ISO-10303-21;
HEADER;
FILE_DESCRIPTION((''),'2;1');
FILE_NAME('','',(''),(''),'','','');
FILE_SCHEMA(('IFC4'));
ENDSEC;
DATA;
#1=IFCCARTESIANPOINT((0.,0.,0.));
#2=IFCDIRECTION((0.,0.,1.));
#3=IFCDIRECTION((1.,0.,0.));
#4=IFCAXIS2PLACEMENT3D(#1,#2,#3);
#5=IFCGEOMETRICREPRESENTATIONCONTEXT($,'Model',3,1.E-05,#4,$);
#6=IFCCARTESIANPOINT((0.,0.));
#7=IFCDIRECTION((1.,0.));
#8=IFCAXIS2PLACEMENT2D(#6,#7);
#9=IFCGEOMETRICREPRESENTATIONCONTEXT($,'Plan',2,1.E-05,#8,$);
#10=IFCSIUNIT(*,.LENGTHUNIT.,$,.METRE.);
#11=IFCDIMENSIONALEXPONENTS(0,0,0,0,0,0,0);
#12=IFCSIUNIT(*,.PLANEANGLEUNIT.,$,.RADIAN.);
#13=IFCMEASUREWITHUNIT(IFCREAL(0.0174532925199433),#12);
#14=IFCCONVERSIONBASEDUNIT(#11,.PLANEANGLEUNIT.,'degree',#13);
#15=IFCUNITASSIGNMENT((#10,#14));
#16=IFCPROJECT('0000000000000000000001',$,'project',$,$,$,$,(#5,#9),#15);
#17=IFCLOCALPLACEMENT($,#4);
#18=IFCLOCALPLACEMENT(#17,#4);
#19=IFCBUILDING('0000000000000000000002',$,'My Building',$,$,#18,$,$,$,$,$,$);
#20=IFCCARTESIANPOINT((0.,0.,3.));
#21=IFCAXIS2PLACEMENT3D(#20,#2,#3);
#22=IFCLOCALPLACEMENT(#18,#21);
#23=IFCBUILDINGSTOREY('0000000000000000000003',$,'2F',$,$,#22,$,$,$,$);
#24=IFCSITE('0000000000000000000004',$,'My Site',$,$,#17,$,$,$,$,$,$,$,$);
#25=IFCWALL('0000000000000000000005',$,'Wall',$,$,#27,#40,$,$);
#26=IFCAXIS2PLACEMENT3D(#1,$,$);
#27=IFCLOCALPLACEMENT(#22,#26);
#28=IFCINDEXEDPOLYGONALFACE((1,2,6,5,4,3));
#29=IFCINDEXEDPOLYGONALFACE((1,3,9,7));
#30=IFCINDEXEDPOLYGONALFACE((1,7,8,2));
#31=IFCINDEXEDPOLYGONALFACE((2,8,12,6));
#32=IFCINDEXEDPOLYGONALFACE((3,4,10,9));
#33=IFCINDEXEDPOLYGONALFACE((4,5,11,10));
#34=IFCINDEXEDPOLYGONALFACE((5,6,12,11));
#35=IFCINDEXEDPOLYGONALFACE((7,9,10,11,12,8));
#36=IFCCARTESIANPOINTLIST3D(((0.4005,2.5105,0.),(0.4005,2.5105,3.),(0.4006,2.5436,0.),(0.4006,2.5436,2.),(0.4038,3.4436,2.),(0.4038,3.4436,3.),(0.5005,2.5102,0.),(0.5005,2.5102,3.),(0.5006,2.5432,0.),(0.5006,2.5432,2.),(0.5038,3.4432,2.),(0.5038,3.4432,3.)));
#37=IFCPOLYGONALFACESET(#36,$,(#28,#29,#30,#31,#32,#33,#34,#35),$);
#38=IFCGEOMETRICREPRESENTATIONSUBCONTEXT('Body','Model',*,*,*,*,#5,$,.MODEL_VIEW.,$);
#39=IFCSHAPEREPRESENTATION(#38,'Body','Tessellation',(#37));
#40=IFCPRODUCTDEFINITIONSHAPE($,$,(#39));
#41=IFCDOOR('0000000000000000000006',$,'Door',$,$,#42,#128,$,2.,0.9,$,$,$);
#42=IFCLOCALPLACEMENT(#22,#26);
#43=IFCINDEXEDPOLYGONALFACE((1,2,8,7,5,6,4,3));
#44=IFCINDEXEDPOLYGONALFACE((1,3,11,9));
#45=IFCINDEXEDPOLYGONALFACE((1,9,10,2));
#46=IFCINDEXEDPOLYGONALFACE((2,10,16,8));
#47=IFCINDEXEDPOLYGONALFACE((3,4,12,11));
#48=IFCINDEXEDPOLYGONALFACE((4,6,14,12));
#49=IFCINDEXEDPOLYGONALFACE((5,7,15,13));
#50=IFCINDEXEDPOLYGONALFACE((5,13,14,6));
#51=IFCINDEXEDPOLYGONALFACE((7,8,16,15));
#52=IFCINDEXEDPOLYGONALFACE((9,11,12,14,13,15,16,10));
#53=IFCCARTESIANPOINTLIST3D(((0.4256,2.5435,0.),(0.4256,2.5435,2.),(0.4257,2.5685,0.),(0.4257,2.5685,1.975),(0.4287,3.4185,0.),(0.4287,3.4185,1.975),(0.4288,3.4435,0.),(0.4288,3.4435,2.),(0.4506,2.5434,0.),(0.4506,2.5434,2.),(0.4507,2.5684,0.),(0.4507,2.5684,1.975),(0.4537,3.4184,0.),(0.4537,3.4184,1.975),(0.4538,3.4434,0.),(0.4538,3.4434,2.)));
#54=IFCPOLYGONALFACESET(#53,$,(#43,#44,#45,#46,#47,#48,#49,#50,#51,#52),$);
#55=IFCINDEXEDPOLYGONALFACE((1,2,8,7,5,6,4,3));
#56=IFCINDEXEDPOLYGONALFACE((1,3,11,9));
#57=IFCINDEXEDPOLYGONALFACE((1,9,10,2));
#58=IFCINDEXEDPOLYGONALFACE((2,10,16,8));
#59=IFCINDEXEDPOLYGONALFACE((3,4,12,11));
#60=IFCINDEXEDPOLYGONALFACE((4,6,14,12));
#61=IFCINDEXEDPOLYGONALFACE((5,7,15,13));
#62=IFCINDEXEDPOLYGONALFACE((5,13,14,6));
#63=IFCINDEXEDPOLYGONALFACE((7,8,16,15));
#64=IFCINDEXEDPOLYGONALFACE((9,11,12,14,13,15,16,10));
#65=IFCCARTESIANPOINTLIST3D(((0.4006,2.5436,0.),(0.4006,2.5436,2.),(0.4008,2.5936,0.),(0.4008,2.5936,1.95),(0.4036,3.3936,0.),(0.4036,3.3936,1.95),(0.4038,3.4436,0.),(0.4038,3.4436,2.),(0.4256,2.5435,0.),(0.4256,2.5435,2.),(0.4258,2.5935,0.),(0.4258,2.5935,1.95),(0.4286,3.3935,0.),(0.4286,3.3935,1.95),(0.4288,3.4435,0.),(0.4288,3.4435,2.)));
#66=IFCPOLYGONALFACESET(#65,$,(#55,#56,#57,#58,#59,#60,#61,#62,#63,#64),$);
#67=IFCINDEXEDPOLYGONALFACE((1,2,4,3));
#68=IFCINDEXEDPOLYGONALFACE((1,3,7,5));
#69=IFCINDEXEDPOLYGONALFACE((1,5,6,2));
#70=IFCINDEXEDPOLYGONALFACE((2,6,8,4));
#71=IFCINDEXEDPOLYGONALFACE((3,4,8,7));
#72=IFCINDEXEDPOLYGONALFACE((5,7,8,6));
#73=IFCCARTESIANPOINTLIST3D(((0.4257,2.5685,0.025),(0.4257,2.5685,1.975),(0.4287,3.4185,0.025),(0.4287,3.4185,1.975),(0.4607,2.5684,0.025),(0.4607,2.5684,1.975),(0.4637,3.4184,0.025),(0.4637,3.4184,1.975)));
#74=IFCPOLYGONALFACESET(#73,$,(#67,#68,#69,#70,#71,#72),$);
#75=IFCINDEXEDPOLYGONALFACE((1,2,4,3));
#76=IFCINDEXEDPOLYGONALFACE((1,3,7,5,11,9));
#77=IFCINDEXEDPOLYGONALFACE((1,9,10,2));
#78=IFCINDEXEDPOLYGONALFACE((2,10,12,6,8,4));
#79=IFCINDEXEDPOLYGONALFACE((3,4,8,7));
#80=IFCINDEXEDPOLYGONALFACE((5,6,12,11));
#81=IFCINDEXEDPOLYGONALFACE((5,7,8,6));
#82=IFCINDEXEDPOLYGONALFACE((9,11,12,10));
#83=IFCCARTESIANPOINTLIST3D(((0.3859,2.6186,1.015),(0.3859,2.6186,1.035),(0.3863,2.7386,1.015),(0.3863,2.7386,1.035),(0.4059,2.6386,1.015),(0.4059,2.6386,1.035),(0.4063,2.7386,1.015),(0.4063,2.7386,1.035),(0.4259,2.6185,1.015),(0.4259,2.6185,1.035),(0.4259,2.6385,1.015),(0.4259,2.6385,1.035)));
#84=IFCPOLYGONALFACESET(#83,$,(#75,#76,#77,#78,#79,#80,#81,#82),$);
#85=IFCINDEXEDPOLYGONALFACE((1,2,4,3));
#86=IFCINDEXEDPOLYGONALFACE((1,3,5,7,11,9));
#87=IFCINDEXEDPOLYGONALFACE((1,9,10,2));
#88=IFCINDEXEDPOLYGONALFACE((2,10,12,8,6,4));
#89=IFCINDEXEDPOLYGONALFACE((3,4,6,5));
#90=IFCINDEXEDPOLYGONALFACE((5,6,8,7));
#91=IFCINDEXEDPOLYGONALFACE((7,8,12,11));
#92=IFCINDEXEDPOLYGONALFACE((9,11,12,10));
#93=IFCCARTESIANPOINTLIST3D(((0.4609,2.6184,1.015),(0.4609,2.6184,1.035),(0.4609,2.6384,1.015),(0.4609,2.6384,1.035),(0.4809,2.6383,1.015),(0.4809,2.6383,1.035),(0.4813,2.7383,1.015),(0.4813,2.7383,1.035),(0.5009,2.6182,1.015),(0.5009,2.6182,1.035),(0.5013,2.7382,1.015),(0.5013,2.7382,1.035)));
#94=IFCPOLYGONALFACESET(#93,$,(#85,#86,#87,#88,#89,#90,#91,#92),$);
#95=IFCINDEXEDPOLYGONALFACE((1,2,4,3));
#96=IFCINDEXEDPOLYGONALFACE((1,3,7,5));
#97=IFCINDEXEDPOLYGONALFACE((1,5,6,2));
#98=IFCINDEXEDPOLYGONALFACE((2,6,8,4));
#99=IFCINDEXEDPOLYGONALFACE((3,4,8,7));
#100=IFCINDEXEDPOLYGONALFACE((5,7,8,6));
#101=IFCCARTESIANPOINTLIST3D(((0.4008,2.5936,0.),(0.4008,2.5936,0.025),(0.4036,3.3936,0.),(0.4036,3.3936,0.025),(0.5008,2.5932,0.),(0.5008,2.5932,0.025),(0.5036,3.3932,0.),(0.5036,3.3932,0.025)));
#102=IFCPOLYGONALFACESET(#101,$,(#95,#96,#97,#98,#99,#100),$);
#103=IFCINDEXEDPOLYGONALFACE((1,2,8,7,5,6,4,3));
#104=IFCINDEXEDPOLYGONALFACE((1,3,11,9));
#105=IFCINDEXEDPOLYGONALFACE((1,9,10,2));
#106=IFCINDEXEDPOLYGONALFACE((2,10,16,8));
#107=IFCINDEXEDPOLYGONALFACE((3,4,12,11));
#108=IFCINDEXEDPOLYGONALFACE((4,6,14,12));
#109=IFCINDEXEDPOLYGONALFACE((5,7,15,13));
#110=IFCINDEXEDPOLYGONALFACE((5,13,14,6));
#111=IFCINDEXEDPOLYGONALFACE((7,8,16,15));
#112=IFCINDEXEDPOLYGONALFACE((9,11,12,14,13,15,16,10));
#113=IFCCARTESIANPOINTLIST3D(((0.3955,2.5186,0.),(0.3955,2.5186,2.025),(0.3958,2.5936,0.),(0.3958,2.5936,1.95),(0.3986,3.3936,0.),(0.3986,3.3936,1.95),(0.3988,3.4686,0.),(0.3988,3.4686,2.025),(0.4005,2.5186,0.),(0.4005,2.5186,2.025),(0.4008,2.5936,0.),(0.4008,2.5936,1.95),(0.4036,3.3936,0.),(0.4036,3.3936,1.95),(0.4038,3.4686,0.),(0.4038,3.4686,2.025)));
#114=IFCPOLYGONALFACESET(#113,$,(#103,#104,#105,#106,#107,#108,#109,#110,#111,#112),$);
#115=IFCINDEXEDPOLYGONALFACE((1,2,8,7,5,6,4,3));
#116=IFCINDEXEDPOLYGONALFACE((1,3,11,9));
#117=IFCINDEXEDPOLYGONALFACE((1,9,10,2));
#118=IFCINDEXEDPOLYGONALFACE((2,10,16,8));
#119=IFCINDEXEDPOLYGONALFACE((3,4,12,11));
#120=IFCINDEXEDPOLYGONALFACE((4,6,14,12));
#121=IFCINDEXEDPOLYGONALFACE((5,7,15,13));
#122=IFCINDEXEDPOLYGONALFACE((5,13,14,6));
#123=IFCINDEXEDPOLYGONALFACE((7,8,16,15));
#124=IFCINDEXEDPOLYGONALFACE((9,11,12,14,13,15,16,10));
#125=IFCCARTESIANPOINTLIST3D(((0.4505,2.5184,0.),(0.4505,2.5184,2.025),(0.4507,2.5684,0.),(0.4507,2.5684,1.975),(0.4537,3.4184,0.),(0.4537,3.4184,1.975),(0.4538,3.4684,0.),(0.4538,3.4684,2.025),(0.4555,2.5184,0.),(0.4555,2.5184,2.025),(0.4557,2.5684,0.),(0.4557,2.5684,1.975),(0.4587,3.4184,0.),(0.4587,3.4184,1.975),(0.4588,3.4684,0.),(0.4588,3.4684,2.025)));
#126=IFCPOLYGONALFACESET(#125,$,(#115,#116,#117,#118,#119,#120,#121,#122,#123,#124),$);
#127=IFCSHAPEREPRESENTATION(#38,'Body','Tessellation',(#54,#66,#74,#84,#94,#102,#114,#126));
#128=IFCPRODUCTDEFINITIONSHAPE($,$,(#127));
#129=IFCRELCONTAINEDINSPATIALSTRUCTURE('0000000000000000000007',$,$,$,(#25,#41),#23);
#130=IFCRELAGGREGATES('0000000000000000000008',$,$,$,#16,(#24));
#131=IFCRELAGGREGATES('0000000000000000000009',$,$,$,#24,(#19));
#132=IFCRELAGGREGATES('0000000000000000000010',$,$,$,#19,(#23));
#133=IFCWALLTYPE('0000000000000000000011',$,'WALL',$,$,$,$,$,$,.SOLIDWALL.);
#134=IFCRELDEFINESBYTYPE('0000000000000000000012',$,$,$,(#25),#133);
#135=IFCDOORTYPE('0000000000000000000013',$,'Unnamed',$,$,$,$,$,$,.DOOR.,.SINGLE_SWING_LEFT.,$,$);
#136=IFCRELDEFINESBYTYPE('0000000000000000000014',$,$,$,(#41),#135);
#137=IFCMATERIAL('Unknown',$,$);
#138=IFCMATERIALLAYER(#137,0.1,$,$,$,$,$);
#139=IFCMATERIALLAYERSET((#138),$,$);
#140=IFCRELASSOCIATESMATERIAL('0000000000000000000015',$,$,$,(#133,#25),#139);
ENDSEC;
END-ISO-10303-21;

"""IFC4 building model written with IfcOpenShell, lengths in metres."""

from ifc_helpers import new_model, entity, si_unit, converted_unit, frame, origin_with_axes, origin_2d_with_axis, place, context, subcontext, project, spatial, line, indexed_curve, outline, extrude, shape, source, transform, mapped, material, layer, layer_set, layer_usage, type_object, type_shapes, element, fill, save


model = new_model("IFC4")

# Units and contexts
model_context = context("Model", 3, precision=1e-05, world=origin_with_axes())
plan_context = context("Plan", 2, precision=1e-05, world=origin_2d_with_axis())
body_context_1 = subcontext(model_context, "Body", "Model", "MODEL_VIEW")
body_context_2 = subcontext(plan_context, "Body", "Plan", "PLAN_VIEW")
ifc_project = project(units=[si_unit("LENGTHUNIT", "METRE"), converted_unit("PLANEANGLEUNIT", "degree", entity("IfcReal", 0.0174532925199433), si_unit("PLANEANGLEUNIT", "RADIAN"), dimensions=[0, 0, 0, 0, 0, 0, 0])], contexts=[model_context, plan_context])

# Site, building, storey
site_placement = place(None, origin_with_axes())
site = spatial("IfcSite", under=ifc_project, at=site_placement, Name="My Site")
building_placement = place(site_placement, origin_with_axes())
building = spatial("IfcBuilding", under=site, at=building_placement, Name="My Building")
storey_placement = place(building_placement, frame((0.0, 0.0, 3.0), z_axis=(0.0, 0.0, 1.0), x_axis=(1.0, 0.0, 0.0)))
storey = spatial("IfcBuildingStorey", under=building, at=storey_placement, Name="2F")

# Shared definitions
ifc_material = material(Name="Unknown")

# Shared definitions
ifc_layer_1 = layer(ifc_material, 0.1)
ifc_layer_set_1 = layer_set([ifc_layer_1])
wall_type = type_object("IfcWallType", Name="WALL", PredefinedType="SOLIDWALL", material=ifc_layer_set_1)

# Wall, opening, door
shared_shape_1 = source(origin_with_axes(), body_context_1, "Body", "SweptSolid", [
    extrude(outline(indexed_curve([(0.0, 0.0), (0.9, 0.0), (0.9, 2.0), (0.0, 2.0)], segments=[line(1, 2, 3, 4, 1)])), frame((0.0, -0.6, 0.0), z_axis=(0.0, -1.0, 0.0), x_axis=(1.0, 0.0, 0.0)), (0.0, 0.0, -1.0), 1.2),
])
door_type = type_object("IfcDoorType", Name="Unnamed", OperationType="SINGLE_SWING_LEFT", PredefinedType="DOOR")
shared_shape_2 = source(origin_with_axes(), body_context_1, "Body", "SweptSolid", [
    extrude(outline(indexed_curve([(0.0, 0.0), (0.0, 2.0), (0.9, 2.0), (0.9, 0.0), (0.875, 0.0), (0.875, 1.975), (0.025, 1.975), (0.025, 0.0)], segments=[line(1, 2, 3, 4, 5, 6, 7, 8, 1)])), frame((0.0, 0.025, 0.0), z_axis=(0.0, -1.0, 0.0), x_axis=(1.0, 0.0, 0.0)), (0.0, 0.0, -1.0), 0.025),
    extrude(outline(indexed_curve([(0.0, 0.0), (0.0, 2.0), (0.9, 2.0), (0.9, 0.0), (0.85, 0.0), (0.85, 1.95), (0.05, 1.95), (0.05, 0.0)], segments=[line(1, 2, 3, 4, 5, 6, 7, 8, 1)])), frame((0.0, 0.0, 0.0), z_axis=(0.0, -1.0, 0.0), x_axis=(1.0, 0.0, 0.0)), (0.0, 0.0, -1.0), 0.025),
    extrude(outline(indexed_curve([(0.0, 0.0), (0.85, 0.0), (0.85, 0.035), (0.0, 0.035)], segments=[line(1, 2, 3, 4, 1)])), frame((0.025, 0.025, 0.025), z_axis=(0.0, 0.0, 1.0), x_axis=(1.0, 0.0, 0.0)), (0.0, 0.0, 1.0), 1.95),
    extrude(outline(indexed_curve([(0.0, 0.0), (0.0, -0.04), (-0.12, -0.04), (-0.12, -0.02), (-0.02, -0.02), (-0.02, 0.0)], segments=[line(1, 2, 3, 4, 5, 6, 1)])), frame((0.825, 0.025, 1.015), z_axis=(0.0, 0.0, 1.0), x_axis=(1.0, 0.0, 0.0)), (0.0, 0.0, 1.0), 0.02),
    extrude(outline(indexed_curve([(0.0, 0.0), (0.0, 0.04), (-0.12, 0.04), (-0.12, 0.02), (-0.02, 0.02), (-0.02, 0.0)], segments=[line(1, 2, 3, 4, 5, 6, 1)])), frame((0.825, 0.06, 1.015), z_axis=(0.0, 0.0, 1.0), x_axis=(1.0, 0.0, 0.0)), (0.0, 0.0, 1.0), 0.02),
    extrude(outline(indexed_curve([(0.0, 0.0), (0.8, 0.0), (0.8, 0.1), (0.0, 0.1)], segments=[line(1, 2, 3, 4, 1)])), frame((0.05, 0.0, 0.0), z_axis=(0.0, 0.0, 1.0), x_axis=(1.0, 0.0, 0.0)), (0.0, 0.0, 1.0), 0.025),
    extrude(outline(indexed_curve([(0.0, 0.0), (0.0, 2.025), (0.95, 2.025), (0.95, 0.0), (0.875, 0.0), (0.875, 1.95), (0.075, 1.95), (0.075, 0.0)], segments=[line(1, 2, 3, 4, 5, 6, 7, 8, 1)])), frame((-0.025, -0.005, 0.0), z_axis=(0.0, -1.0, 0.0), x_axis=(1.0, 0.0, 0.0)), (0.0, 0.0, -1.0), 0.005),
    extrude(outline(indexed_curve([(0.0, 0.0), (0.0, 2.025), (0.95, 2.025), (0.95, 0.0), (0.9, 0.0), (0.9, 1.975), (0.05, 1.975), (0.05, 0.0)], segments=[line(1, 2, 3, 4, 5, 6, 7, 8, 1)])), frame((-0.025, 0.05, 0.0), z_axis=(0.0, -1.0, 0.0), x_axis=(1.0, 0.0, 0.0)), (0.0, 0.0, -1.0), 0.005),
])
shared_shape_3 = source(origin_with_axes(), body_context_2, "Body", "Curve2D", [
    entity("IfcIndexedPolyCurve", entity("IfcCartesianPointList2D", [[0.0, 0.0], [0.0, 0.05], [0.025, 0.05], [0.025, 0.025], [0.05, 0.025], [0.05, 0.0]]), [entity("IfcLineIndex", [1, 2, 3, 4, 5, 6, 1])]),
    entity("IfcIndexedPolyCurve", entity("IfcCartesianPointList2D", [[0.9, 0.0], [0.9, 0.05], [0.875, 0.05], [0.875, 0.025], [0.85, 0.025], [0.85, 0.0]]), [entity("IfcLineIndex", [1, 2, 3, 4, 5, 6, 1])]),
    entity("IfcTrimmedCurve", entity("IfcEllipse", entity("IfcAxis2Placement2D", entity("IfcCartesianPoint", [0.06, 0.05]), entity("IfcDirection", [1.0, 0.0])), 0.815, 0.85), [entity("IfcCartesianPoint", [0.875, 0.05])], [entity("IfcCartesianPoint", [0.06, 0.9])], True, "CARTESIAN"),
    entity("IfcIndexedPolyCurve", entity("IfcCartesianPointList2D", [[0.025, 0.05], [0.06, 0.05], [0.06, 0.9], [0.025, 0.9]]), [entity("IfcLineIndex", [1, 2, 3, 4, 1])]),
])
type_shapes(door_type, [shared_shape_2, shared_shape_3])
ifc_layer_usage_1 = layer_usage(ifc_layer_set_1, "AXIS2", "POSITIVE", 0.0)
wall_1_placement = place(storey_placement, frame((0.4038, 3.4436, 0.0), z_axis=(0.0, 0.0, 1.0), x_axis=(-0.003501, -0.999994, 0.0)))
wall_1 = element("IfcWall", 1, at=wall_1_placement, inside=storey, type_object=wall_type, material=ifc_layer_usage_1, Name="Wall", context=body_context_1, shape_type="SweptSolid", body=[
    extrude(outline(indexed_curve([(0.0, 0.0), (0.0, 0.1), (0.933, 0.1), (0.933, 0.0)], segments=[line(1, 2, 3, 4, 1)])), origin_with_axes(), (0.0, 0.0, 1.0), 3.0),
])
opening_1_placement = place(wall_1_placement, frame((0.0, 0.0, 0.0), z_axis=(0.0, 0.0, 1.0), x_axis=(1.0, 0.0, 0.0)))
opening_1 = element("IfcOpeningElement", 2, at=opening_1_placement, cuts=wall_1, PredefinedType="OPENING", context=body_context_1, shape_type="MappedRepresentation", body=[
    mapped(shared_shape_1, transform((0.0, 0.0, 0.0), x_axis=(1.0, 0.0, 0.0), y_axis=(0.0, 1.0, 0.0), z_axis=(0.0, 0.0, 1.0), scale=1.0)),
])
door_1_placement = place(opening_1_placement, frame((0.0, 0.0, 0.0), z_axis=(0.0, 0.0, 1.0), x_axis=(1.0, 0.0, 0.0)))
door_1 = element("IfcDoor", 3, at=door_1_placement, inside=storey, type_object=door_type, Name="Door", OverallHeight=2.0, OverallWidth=0.9, shapes=[
    shape(body_context_1, "Body", "MappedRepresentation", [mapped(shared_shape_2, transform((0.0, 0.0, 0.0), x_axis=(1.0, 0.0, 0.0), y_axis=(0.0, 1.0, 0.0), z_axis=(0.0, 0.0, 1.0), scale=1.0))]),
    shape(body_context_2, "Body", "MappedRepresentation", [mapped(shared_shape_3, transform((0.0, 0.0, 0.0), x_axis=(1.0, 0.0, 0.0), y_axis=(0.0, 1.0, 0.0), z_axis=(0.0, 0.0, 1.0), scale=1.0))]),
])
fill(opening_1, door_1)

save(model, "model.ifc")
